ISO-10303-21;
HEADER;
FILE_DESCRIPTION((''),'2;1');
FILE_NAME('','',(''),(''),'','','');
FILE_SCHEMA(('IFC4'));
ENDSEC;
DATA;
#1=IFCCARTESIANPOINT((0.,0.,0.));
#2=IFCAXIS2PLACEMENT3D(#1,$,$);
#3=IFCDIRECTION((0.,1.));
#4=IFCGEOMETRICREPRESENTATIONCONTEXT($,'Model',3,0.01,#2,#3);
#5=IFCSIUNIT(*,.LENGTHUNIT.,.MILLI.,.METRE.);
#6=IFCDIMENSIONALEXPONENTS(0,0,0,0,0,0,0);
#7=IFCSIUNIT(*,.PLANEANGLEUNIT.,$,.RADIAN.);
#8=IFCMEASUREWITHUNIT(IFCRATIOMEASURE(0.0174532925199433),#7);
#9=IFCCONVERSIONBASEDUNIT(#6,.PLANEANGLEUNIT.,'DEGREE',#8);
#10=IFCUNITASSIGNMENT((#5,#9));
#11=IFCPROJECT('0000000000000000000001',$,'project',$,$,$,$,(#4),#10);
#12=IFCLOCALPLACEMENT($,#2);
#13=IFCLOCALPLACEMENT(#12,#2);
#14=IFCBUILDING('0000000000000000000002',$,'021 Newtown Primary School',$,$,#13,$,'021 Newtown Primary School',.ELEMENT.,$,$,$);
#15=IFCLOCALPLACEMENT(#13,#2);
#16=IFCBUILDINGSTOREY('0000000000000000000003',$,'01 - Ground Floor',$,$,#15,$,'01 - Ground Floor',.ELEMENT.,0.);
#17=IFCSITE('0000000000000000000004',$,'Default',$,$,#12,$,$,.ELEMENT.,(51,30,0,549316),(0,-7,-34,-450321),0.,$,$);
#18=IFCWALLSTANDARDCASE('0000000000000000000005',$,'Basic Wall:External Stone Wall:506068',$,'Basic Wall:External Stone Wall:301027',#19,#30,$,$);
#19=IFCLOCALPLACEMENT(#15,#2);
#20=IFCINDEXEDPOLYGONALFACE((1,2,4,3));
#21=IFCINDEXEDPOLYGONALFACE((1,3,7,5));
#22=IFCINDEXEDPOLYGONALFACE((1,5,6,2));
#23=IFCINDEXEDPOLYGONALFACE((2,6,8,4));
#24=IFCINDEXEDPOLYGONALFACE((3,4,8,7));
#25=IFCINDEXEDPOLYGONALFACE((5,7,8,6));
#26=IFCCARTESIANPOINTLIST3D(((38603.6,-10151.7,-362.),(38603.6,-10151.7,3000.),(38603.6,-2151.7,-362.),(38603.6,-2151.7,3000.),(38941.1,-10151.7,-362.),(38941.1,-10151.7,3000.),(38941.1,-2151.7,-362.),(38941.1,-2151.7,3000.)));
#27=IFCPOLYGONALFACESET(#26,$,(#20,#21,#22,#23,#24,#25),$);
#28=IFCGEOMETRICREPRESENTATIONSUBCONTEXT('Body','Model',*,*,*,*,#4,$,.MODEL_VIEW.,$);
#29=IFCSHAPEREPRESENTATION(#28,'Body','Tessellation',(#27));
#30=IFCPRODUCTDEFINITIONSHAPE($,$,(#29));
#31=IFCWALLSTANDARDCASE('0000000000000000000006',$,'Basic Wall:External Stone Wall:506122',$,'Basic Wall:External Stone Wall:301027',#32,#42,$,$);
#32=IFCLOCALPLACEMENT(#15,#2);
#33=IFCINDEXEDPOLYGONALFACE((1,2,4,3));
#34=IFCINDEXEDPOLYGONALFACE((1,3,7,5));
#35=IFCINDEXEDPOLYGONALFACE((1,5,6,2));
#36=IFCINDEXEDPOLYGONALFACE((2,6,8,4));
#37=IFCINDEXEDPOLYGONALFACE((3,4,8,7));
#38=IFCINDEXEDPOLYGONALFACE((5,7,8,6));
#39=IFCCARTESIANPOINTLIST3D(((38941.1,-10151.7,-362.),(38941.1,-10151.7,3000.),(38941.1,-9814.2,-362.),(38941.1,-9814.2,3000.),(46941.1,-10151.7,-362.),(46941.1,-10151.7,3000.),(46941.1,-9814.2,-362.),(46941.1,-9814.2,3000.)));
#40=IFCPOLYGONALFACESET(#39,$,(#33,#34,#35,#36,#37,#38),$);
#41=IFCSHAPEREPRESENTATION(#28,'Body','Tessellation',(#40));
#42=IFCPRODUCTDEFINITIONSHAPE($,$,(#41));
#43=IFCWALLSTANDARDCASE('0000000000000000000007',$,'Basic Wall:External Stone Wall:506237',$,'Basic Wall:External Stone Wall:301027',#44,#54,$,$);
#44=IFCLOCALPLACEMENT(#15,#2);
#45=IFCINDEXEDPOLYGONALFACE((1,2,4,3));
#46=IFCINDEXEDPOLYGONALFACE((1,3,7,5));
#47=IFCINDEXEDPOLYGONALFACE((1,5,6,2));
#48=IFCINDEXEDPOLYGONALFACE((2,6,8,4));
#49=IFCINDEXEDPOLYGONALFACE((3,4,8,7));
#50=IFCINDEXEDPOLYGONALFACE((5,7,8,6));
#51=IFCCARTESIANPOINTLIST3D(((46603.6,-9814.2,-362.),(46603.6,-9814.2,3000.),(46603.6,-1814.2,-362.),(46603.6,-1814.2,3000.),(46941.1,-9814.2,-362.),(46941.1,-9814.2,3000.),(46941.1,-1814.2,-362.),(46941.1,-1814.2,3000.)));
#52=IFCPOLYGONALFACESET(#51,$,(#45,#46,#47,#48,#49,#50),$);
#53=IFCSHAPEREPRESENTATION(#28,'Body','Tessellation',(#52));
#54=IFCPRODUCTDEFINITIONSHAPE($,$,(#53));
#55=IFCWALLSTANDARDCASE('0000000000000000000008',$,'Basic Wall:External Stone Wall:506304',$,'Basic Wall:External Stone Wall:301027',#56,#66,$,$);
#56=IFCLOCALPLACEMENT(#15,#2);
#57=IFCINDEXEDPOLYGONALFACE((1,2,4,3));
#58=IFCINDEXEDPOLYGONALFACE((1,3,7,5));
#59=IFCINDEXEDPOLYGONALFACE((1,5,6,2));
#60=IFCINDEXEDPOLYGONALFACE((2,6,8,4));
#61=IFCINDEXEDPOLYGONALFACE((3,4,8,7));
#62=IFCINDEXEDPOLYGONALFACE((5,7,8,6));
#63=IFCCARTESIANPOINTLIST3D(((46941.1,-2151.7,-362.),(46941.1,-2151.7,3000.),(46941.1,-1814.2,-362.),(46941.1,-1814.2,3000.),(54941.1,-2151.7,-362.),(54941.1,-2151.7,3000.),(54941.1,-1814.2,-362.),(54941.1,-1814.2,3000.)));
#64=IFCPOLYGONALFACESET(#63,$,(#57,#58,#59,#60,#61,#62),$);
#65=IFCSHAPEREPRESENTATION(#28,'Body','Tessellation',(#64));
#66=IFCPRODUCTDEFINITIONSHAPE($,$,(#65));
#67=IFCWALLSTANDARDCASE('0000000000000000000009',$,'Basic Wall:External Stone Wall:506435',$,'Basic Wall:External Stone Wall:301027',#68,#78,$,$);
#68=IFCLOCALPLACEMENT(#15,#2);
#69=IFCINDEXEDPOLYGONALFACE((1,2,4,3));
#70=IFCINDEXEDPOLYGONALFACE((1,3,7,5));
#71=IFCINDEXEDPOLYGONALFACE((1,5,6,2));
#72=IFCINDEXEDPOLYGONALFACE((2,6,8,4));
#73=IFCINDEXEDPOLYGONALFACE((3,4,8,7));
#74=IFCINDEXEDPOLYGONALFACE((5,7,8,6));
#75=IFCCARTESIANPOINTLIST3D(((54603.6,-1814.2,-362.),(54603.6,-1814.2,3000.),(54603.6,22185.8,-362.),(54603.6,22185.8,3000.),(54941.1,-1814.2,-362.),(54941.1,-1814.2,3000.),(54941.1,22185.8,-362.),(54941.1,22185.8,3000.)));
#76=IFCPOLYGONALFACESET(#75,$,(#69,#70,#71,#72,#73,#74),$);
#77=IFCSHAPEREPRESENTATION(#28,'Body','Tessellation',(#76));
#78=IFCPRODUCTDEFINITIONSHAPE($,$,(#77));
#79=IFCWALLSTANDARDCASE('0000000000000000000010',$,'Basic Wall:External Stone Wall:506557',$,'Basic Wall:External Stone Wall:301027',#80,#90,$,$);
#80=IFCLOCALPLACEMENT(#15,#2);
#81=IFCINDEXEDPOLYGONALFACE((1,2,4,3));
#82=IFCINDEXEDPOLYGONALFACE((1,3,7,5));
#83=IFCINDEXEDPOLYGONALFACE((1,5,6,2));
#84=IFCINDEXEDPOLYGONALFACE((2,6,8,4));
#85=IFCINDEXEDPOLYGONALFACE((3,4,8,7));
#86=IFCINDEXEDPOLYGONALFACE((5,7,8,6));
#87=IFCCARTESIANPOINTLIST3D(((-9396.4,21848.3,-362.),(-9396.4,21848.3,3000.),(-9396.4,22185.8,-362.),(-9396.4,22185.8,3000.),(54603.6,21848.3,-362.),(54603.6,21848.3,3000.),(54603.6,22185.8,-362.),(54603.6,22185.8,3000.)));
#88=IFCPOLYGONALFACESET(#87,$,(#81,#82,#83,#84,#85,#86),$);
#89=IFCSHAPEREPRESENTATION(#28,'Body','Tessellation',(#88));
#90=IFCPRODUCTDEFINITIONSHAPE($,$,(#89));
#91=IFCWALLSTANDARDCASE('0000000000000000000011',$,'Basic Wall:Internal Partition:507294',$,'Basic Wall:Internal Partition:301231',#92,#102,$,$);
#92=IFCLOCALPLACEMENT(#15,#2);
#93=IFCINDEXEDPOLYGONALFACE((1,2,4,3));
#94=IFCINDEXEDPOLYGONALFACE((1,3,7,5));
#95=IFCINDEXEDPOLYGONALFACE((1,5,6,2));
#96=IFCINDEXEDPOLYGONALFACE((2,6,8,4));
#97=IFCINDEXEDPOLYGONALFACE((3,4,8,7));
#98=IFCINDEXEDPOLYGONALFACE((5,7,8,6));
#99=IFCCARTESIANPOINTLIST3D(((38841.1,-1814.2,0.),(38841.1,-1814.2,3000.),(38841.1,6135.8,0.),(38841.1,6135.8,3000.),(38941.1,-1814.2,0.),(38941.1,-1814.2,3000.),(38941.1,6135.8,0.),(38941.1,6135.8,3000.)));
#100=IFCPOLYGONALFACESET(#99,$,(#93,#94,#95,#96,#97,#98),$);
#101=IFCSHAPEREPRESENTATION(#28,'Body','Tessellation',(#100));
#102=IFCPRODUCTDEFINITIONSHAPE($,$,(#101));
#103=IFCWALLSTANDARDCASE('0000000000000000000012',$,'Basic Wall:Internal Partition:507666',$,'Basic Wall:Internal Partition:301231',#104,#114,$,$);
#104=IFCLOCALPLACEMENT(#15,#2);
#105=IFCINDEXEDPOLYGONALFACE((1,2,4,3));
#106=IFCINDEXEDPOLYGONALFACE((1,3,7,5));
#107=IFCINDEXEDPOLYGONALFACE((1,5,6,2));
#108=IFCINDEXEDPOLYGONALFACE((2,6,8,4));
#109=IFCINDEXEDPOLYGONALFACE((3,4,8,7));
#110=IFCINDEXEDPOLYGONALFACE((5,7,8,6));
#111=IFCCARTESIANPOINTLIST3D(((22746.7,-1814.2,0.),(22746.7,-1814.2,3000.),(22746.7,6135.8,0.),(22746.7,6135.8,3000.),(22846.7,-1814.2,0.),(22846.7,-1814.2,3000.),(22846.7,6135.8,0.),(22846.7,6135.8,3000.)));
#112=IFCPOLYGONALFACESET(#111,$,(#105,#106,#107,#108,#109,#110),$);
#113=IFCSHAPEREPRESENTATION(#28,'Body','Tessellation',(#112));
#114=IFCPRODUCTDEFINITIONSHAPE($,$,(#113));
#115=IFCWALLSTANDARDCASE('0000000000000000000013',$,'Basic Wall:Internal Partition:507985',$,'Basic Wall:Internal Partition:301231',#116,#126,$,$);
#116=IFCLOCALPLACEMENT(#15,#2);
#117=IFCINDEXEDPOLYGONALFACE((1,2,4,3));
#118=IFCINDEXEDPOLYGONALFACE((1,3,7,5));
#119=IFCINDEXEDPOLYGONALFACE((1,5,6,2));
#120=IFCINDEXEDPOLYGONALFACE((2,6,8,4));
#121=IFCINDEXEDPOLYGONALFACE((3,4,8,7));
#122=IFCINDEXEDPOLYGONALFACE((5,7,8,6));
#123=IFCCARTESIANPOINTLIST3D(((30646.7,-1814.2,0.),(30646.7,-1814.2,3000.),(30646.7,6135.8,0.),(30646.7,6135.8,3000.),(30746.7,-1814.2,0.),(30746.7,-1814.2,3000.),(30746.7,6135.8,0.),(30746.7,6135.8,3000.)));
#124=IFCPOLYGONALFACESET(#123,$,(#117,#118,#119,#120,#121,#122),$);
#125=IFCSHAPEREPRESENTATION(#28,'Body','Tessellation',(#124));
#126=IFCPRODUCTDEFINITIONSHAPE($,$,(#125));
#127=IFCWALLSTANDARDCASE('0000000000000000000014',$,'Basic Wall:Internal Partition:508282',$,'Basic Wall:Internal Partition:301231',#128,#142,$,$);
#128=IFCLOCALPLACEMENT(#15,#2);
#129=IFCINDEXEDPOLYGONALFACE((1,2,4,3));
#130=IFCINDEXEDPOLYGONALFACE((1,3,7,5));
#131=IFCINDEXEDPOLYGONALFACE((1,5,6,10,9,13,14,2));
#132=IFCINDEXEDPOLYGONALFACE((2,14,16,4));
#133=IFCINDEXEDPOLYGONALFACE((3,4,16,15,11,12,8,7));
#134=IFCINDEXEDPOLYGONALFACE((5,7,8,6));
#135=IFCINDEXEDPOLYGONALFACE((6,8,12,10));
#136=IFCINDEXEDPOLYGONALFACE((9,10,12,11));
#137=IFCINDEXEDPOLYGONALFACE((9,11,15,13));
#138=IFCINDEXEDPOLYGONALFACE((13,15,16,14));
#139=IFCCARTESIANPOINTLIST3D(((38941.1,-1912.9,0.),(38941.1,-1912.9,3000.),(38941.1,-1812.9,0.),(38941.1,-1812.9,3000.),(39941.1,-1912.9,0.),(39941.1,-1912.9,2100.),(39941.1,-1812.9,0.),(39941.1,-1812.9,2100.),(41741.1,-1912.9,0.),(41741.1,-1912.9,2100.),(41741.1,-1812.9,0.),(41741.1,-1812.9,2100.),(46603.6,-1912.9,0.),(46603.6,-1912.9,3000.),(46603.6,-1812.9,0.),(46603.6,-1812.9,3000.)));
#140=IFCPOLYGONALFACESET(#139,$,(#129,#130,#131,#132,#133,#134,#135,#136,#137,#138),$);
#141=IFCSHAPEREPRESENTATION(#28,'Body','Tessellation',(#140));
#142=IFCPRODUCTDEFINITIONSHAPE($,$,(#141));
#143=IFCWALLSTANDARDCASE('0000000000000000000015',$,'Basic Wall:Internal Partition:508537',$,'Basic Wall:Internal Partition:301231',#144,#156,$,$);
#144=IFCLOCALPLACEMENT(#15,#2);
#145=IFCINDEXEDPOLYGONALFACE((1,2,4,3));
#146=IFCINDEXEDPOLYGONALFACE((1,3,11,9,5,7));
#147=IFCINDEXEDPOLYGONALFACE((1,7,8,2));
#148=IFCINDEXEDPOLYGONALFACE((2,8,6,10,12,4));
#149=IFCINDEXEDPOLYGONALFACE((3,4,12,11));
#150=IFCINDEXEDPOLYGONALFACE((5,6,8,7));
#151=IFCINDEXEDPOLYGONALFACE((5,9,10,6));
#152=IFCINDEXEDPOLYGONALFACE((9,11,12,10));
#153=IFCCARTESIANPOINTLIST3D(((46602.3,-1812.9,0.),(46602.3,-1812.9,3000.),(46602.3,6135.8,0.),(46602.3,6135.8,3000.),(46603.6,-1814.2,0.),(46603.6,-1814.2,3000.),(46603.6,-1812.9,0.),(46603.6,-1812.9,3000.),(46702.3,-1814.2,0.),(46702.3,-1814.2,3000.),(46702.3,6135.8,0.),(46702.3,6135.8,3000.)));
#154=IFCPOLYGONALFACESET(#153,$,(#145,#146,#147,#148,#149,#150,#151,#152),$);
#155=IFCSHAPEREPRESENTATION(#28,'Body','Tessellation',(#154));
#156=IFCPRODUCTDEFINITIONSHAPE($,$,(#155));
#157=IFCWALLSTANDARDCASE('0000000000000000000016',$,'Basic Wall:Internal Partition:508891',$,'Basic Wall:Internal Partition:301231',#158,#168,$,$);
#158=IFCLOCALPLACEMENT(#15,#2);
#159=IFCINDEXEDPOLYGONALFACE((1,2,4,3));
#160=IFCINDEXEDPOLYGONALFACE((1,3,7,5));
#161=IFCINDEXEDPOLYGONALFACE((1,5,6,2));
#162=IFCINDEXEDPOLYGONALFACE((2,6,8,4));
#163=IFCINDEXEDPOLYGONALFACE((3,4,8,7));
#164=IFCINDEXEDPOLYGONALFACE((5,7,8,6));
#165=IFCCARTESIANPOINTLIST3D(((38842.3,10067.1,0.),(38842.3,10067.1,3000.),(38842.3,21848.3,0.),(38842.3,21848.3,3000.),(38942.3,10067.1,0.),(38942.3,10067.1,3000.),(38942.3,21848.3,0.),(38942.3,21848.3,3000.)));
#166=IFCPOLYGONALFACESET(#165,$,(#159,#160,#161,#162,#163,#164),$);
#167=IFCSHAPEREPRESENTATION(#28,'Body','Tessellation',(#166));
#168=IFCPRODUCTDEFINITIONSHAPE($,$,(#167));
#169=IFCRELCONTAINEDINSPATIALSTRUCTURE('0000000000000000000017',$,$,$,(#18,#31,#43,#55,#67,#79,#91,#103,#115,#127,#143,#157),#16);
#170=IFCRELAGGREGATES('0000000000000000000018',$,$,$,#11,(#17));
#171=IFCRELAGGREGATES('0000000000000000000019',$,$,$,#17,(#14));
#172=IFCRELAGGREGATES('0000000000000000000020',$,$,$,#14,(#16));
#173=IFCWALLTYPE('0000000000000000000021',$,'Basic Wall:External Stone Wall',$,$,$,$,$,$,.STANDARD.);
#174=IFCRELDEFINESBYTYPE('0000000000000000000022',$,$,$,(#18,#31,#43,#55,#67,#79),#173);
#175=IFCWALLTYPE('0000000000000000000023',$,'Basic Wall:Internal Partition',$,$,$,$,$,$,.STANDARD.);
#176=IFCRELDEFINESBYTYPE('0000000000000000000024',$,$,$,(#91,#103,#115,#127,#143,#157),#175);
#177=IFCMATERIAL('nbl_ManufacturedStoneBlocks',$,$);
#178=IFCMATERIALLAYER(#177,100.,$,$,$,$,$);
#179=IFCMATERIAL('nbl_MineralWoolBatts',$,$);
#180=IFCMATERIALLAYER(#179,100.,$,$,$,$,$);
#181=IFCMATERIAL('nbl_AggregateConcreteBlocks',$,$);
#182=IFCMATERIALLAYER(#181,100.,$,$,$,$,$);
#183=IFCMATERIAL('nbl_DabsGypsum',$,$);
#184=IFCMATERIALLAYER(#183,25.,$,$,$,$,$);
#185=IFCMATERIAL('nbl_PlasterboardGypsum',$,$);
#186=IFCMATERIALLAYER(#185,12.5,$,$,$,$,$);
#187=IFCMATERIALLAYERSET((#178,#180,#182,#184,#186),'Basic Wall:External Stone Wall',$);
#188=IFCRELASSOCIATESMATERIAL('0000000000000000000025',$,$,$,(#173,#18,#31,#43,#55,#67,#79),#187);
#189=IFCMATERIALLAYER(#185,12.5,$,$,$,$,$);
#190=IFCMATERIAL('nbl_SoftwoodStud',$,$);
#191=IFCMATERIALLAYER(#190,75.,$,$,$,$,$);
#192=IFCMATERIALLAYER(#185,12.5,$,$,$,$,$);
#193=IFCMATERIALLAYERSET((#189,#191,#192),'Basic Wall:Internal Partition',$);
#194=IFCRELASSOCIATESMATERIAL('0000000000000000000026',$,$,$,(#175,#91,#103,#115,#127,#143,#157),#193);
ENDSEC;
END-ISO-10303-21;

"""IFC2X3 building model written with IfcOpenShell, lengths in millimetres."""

from ifc_helpers import new_model, entity, si_unit, converted_unit, direction, frame, frame_2d, origin, place, context, subcontext, project, spatial, polyline, rectangle, outline, extrude, material, layer, layer_set, layer_usage, type_object, element, save


model = new_model("IFC2X3")

# Units and contexts
model_context = context("Model", 3, precision=0.01, world=origin(), true_north=direction((0.0, 1.0)))
body_context = subcontext(model_context, "Body", "Model", "MODEL_VIEW")
ifc_project = project(units=[si_unit("LENGTHUNIT", "METRE", prefix="MILLI"), converted_unit("PLANEANGLEUNIT", "DEGREE", entity("IfcRatioMeasure", 0.0174532925199433), si_unit("PLANEANGLEUNIT", "RADIAN"), dimensions=[0, 0, 0, 0, 0, 0, 0])], contexts=[model_context])

# Site, building, storey
site_placement = place(None, origin())
site = spatial("IfcSite", under=ifc_project, at=site_placement, Name="Default", CompositionType="ELEMENT", RefLatitude=(51, 30, 0, 549316), RefLongitude=(0, -7, -34, -450321), RefElevation=0.0)
building_placement = place(site_placement, origin())
building = spatial("IfcBuilding", under=site, at=building_placement, Name="021 Newtown Primary School", LongName="021 Newtown Primary School", CompositionType="ELEMENT")
storey_placement = place(building_placement, origin())
storey = spatial("IfcBuildingStorey", under=building, at=storey_placement, Name="01 - Ground Floor", LongName="01 - Ground Floor", CompositionType="ELEMENT", Elevation=0.0)

# Walls
ifc_material_1 = material(Name="nbl_ManufacturedStoneBlocks")
ifc_layer_1 = layer(ifc_material_1, 100.0)
ifc_material_2 = material(Name="nbl_MineralWoolBatts")
ifc_layer_2 = layer(ifc_material_2, 100.0)
ifc_material_3 = material(Name="nbl_AggregateConcreteBlocks")
ifc_layer_3 = layer(ifc_material_3, 100.0)
ifc_material_4 = material(Name="nbl_DabsGypsum")
ifc_layer_4 = layer(ifc_material_4, 25.0)
ifc_material_5 = material(Name="nbl_PlasterboardGypsum")
ifc_layer_5 = layer(ifc_material_5, 12.5)
ifc_layer_set_1 = layer_set([ifc_layer_1, ifc_layer_2, ifc_layer_3, ifc_layer_4, ifc_layer_5], Name="Basic Wall:External Stone Wall")
ifc_layer_usage_1 = layer_usage(ifc_layer_set_1, "AXIS2", "NEGATIVE", 168.8)
wall_type_1 = type_object("IfcWallType", Name="Basic Wall:External Stone Wall", PredefinedType="STANDARD", material=ifc_layer_set_1)
wall_1_placement = place(storey_placement, frame((38772.3, -2151.7, -362.0), z_axis=(0.0, 0.0, 1.0), x_axis=(0.0, -1.0, 0.0)))
element("IfcWallStandardCase", 1, at=wall_1_placement, inside=storey, type_object=wall_type_1, material=ifc_layer_usage_1, Name="Basic Wall:External Stone Wall:506068", ObjectType="Basic Wall:External Stone Wall:301027", context=body_context, shape_type="SweptSolid", body=[
    extrude(rectangle(XDim=8000.0, YDim=337.5, at=frame_2d((4000.0, 0.0), x_axis=(-1.0, 0.0))), origin(), (0.0, 0.0, 1.0), 3362.0),
])
ifc_layer_usage_2 = layer_usage(ifc_layer_set_1, "AXIS2", "NEGATIVE", 168.8)
wall_2_placement = place(storey_placement, frame((38941.1, -9982.9, -362.0)))
element("IfcWallStandardCase", 2, at=wall_2_placement, inside=storey, type_object=wall_type_1, material=ifc_layer_usage_2, Name="Basic Wall:External Stone Wall:506122", ObjectType="Basic Wall:External Stone Wall:301027", context=body_context, shape_type="SweptSolid", body=[
    extrude(rectangle(XDim=8000.0, YDim=337.5, at=frame_2d((4000.0, 0.0), x_axis=(-1.0, 0.0))), origin(), (0.0, 0.0, 1.0), 3362.0),
])
ifc_layer_usage_3 = layer_usage(ifc_layer_set_1, "AXIS2", "NEGATIVE", 168.8)
wall_3_placement = place(storey_placement, frame((46772.3, -9814.2, -362.0), z_axis=(0.0, 0.0, 1.0), x_axis=(0.0, 1.0, 0.0)))
element("IfcWallStandardCase", 3, at=wall_3_placement, inside=storey, type_object=wall_type_1, material=ifc_layer_usage_3, Name="Basic Wall:External Stone Wall:506237", ObjectType="Basic Wall:External Stone Wall:301027", context=body_context, shape_type="SweptSolid", body=[
    extrude(rectangle(XDim=8000.0, YDim=337.5, at=frame_2d((4000.0, 0.0), x_axis=(-1.0, 0.0))), origin(), (0.0, 0.0, 1.0), 3362.0),
])
ifc_layer_usage_4 = layer_usage(ifc_layer_set_1, "AXIS2", "NEGATIVE", 168.8)
wall_4_placement = place(storey_placement, frame((46941.1, -1982.9, -362.0)))
element("IfcWallStandardCase", 4, at=wall_4_placement, inside=storey, type_object=wall_type_1, material=ifc_layer_usage_4, Name="Basic Wall:External Stone Wall:506304", ObjectType="Basic Wall:External Stone Wall:301027", context=body_context, shape_type="SweptSolid", body=[
    extrude(rectangle(XDim=8000.0, YDim=337.5, at=frame_2d((4000.0, 0.0), x_axis=(-1.0, 0.0))), origin(), (0.0, 0.0, 1.0), 3362.0),
])
ifc_layer_usage_5 = layer_usage(ifc_layer_set_1, "AXIS2", "NEGATIVE", 168.8)
wall_5_placement = place(storey_placement, frame((54772.3, -1814.2, -362.0), z_axis=(0.0, 0.0, 1.0), x_axis=(0.0, 1.0, 0.0)))
element("IfcWallStandardCase", 5, at=wall_5_placement, inside=storey, type_object=wall_type_1, material=ifc_layer_usage_5, Name="Basic Wall:External Stone Wall:506435", ObjectType="Basic Wall:External Stone Wall:301027", context=body_context, shape_type="SweptSolid", body=[
    extrude(rectangle(XDim=24000.0, YDim=337.5, at=frame_2d((12000.0, 0.0), x_axis=(-1.0, 0.0))), origin(), (0.0, 0.0, 1.0), 3362.0),
])
ifc_layer_usage_6 = layer_usage(ifc_layer_set_1, "AXIS2", "NEGATIVE", 168.8)
wall_6_placement = place(storey_placement, frame((54603.6, 22017.1, -362.0), z_axis=(0.0, 0.0, 1.0), x_axis=(-1.0, 0.0, 0.0)))
element("IfcWallStandardCase", 6, at=wall_6_placement, inside=storey, type_object=wall_type_1, material=ifc_layer_usage_6, Name="Basic Wall:External Stone Wall:506557", ObjectType="Basic Wall:External Stone Wall:301027", context=body_context, shape_type="SweptSolid", body=[
    extrude(rectangle(XDim=64000.0, YDim=337.5, at=frame_2d((32000.0, 0.0), x_axis=(-1.0, 0.0))), origin(), (0.0, 0.0, 1.0), 3362.0),
])
ifc_layer_6 = layer(ifc_material_5, 12.5)
ifc_material_6 = material(Name="nbl_SoftwoodStud")
ifc_layer_7 = layer(ifc_material_6, 75.0)
ifc_layer_8 = layer(ifc_material_5, 12.5)
ifc_layer_set_2 = layer_set([ifc_layer_6, ifc_layer_7, ifc_layer_8], Name="Basic Wall:Internal Partition")
ifc_layer_usage_7 = layer_usage(ifc_layer_set_2, "AXIS2", "NEGATIVE", 50.0)
wall_type_2 = type_object("IfcWallType", Name="Basic Wall:Internal Partition", PredefinedType="STANDARD", material=ifc_layer_set_2)
wall_7_placement = place(storey_placement, frame((38891.1, -1814.2, 0.0), z_axis=(0.0, 0.0, 1.0), x_axis=(0.0, 1.0, 0.0)))
element("IfcWallStandardCase", 7, at=wall_7_placement, inside=storey, type_object=wall_type_2, material=ifc_layer_usage_7, Name="Basic Wall:Internal Partition:507294", ObjectType="Basic Wall:Internal Partition:301231", context=body_context, shape_type="SweptSolid", body=[
    extrude(rectangle(XDim=7950.0, YDim=100.0, at=frame_2d((3975.0, 0.0), x_axis=(-1.0, 0.0))), origin(), (0.0, 0.0, 1.0), 3000.0),
])

# Walls
ifc_layer_usage_8 = layer_usage(ifc_layer_set_2, "AXIS2", "NEGATIVE", 50.0)
wall_8_placement = place(storey_placement, frame((22796.7, 6135.8, 0.0), z_axis=(0.0, 0.0, 1.0), x_axis=(0.0, -1.0, 0.0)))
element("IfcWallStandardCase", 8, at=wall_8_placement, inside=storey, type_object=wall_type_2, material=ifc_layer_usage_8, Name="Basic Wall:Internal Partition:507666", ObjectType="Basic Wall:Internal Partition:301231", context=body_context, shape_type="SweptSolid", body=[
    extrude(rectangle(XDim=7950.0, YDim=100.0, at=frame_2d((3975.0, 0.0), x_axis=(-1.0, 0.0))), origin(), (0.0, 0.0, 1.0), 3000.0),
])
ifc_layer_usage_9 = layer_usage(ifc_layer_set_2, "AXIS2", "NEGATIVE", 50.0)
wall_9_placement = place(storey_placement, frame((30696.7, 6135.8, 0.0), z_axis=(0.0, 0.0, 1.0), x_axis=(0.0, -1.0, 0.0)))
element("IfcWallStandardCase", 9, at=wall_9_placement, inside=storey, type_object=wall_type_2, material=ifc_layer_usage_9, Name="Basic Wall:Internal Partition:507985", ObjectType="Basic Wall:Internal Partition:301231", context=body_context, shape_type="SweptSolid", body=[
    extrude(rectangle(XDim=7950.0, YDim=100.0, at=frame_2d((3975.0, 0.0), x_axis=(-1.0, 0.0))), origin(), (0.0, 0.0, 1.0), 3000.0),
])

# Wall, opening
ifc_layer_usage_10 = layer_usage(ifc_layer_set_2, "AXIS2", "NEGATIVE", 50.0)
wall_10_placement = place(storey_placement, frame((46603.6, -1862.9, 0.0), z_axis=(0.0, 0.0, 1.0), x_axis=(-1.0, 0.0, 0.0)))
wall_10 = element("IfcWallStandardCase", 10, at=wall_10_placement, inside=storey, type_object=wall_type_2, material=ifc_layer_usage_10, Name="Basic Wall:Internal Partition:508282", ObjectType="Basic Wall:Internal Partition:301231", context=body_context, shape_type="SweptSolid", body=[
    extrude(rectangle(XDim=7662.5, YDim=100.0, at=frame_2d((3831.2, 0.0), x_axis=(-1.0, 0.0))), origin(), (0.0, 0.0, 1.0), 3000.0),
])
opening_1_placement = place(wall_10_placement, origin())
element("IfcOpeningElement", 11, at=opening_1_placement, cuts=wall_10, ObjectType="Opening", context=body_context, shape_type="SweptSolid", body=[
    extrude(rectangle(XDim=2100.0, YDim=1800.0, at=frame_2d((0.0, 0.0), x_axis=(0.0, 1.0))), frame((5762.5, -1574.0, 1050.0), z_axis=(0.0, 1.0, 0.0), x_axis=(-1.0, 0.0, 0.0)), (0.0, 0.0, 1.0), 3048.0),
])

# Walls
ifc_layer_usage_11 = layer_usage(ifc_layer_set_2, "AXIS2", "NEGATIVE", 50.0)
wall_11_placement = place(storey_placement, frame((46652.3, 6135.8, 0.0), z_axis=(0.0, 0.0, 1.0), x_axis=(0.0, -1.0, 0.0)))
element("IfcWallStandardCase", 12, at=wall_11_placement, inside=storey, type_object=wall_type_2, material=ifc_layer_usage_11, Name="Basic Wall:Internal Partition:508537", ObjectType="Basic Wall:Internal Partition:301231", context=body_context, shape_type="SweptSolid", body=[
    extrude(outline(polyline([(7948.8, -50.0), (7948.8, -48.7), (7950.0, -48.7), (7950.0, 50.0), (0.0, 50.0), (0.0, -50.0), (7948.8, -50.0)])), origin(), (0.0, 0.0, 1.0), 3000.0),
])
ifc_layer_usage_12 = layer_usage(ifc_layer_set_2, "AXIS2", "NEGATIVE", 50.0)
wall_12_placement = place(storey_placement, frame((38892.3, 10067.1, 0.0), z_axis=(0.0, 0.0, 1.0), x_axis=(0.0, 1.0, 0.0)))
element("IfcWallStandardCase", 13, at=wall_12_placement, inside=storey, type_object=wall_type_2, material=ifc_layer_usage_12, Name="Basic Wall:Internal Partition:508891", ObjectType="Basic Wall:Internal Partition:301231", context=body_context, shape_type="SweptSolid", body=[
    extrude(rectangle(XDim=11781.2, YDim=100.0, at=frame_2d((5890.6, 0.0), x_axis=(-1.0, 0.0))), origin(), (0.0, 0.0, 1.0), 3000.0),
])

save(model, "model.ifc")
